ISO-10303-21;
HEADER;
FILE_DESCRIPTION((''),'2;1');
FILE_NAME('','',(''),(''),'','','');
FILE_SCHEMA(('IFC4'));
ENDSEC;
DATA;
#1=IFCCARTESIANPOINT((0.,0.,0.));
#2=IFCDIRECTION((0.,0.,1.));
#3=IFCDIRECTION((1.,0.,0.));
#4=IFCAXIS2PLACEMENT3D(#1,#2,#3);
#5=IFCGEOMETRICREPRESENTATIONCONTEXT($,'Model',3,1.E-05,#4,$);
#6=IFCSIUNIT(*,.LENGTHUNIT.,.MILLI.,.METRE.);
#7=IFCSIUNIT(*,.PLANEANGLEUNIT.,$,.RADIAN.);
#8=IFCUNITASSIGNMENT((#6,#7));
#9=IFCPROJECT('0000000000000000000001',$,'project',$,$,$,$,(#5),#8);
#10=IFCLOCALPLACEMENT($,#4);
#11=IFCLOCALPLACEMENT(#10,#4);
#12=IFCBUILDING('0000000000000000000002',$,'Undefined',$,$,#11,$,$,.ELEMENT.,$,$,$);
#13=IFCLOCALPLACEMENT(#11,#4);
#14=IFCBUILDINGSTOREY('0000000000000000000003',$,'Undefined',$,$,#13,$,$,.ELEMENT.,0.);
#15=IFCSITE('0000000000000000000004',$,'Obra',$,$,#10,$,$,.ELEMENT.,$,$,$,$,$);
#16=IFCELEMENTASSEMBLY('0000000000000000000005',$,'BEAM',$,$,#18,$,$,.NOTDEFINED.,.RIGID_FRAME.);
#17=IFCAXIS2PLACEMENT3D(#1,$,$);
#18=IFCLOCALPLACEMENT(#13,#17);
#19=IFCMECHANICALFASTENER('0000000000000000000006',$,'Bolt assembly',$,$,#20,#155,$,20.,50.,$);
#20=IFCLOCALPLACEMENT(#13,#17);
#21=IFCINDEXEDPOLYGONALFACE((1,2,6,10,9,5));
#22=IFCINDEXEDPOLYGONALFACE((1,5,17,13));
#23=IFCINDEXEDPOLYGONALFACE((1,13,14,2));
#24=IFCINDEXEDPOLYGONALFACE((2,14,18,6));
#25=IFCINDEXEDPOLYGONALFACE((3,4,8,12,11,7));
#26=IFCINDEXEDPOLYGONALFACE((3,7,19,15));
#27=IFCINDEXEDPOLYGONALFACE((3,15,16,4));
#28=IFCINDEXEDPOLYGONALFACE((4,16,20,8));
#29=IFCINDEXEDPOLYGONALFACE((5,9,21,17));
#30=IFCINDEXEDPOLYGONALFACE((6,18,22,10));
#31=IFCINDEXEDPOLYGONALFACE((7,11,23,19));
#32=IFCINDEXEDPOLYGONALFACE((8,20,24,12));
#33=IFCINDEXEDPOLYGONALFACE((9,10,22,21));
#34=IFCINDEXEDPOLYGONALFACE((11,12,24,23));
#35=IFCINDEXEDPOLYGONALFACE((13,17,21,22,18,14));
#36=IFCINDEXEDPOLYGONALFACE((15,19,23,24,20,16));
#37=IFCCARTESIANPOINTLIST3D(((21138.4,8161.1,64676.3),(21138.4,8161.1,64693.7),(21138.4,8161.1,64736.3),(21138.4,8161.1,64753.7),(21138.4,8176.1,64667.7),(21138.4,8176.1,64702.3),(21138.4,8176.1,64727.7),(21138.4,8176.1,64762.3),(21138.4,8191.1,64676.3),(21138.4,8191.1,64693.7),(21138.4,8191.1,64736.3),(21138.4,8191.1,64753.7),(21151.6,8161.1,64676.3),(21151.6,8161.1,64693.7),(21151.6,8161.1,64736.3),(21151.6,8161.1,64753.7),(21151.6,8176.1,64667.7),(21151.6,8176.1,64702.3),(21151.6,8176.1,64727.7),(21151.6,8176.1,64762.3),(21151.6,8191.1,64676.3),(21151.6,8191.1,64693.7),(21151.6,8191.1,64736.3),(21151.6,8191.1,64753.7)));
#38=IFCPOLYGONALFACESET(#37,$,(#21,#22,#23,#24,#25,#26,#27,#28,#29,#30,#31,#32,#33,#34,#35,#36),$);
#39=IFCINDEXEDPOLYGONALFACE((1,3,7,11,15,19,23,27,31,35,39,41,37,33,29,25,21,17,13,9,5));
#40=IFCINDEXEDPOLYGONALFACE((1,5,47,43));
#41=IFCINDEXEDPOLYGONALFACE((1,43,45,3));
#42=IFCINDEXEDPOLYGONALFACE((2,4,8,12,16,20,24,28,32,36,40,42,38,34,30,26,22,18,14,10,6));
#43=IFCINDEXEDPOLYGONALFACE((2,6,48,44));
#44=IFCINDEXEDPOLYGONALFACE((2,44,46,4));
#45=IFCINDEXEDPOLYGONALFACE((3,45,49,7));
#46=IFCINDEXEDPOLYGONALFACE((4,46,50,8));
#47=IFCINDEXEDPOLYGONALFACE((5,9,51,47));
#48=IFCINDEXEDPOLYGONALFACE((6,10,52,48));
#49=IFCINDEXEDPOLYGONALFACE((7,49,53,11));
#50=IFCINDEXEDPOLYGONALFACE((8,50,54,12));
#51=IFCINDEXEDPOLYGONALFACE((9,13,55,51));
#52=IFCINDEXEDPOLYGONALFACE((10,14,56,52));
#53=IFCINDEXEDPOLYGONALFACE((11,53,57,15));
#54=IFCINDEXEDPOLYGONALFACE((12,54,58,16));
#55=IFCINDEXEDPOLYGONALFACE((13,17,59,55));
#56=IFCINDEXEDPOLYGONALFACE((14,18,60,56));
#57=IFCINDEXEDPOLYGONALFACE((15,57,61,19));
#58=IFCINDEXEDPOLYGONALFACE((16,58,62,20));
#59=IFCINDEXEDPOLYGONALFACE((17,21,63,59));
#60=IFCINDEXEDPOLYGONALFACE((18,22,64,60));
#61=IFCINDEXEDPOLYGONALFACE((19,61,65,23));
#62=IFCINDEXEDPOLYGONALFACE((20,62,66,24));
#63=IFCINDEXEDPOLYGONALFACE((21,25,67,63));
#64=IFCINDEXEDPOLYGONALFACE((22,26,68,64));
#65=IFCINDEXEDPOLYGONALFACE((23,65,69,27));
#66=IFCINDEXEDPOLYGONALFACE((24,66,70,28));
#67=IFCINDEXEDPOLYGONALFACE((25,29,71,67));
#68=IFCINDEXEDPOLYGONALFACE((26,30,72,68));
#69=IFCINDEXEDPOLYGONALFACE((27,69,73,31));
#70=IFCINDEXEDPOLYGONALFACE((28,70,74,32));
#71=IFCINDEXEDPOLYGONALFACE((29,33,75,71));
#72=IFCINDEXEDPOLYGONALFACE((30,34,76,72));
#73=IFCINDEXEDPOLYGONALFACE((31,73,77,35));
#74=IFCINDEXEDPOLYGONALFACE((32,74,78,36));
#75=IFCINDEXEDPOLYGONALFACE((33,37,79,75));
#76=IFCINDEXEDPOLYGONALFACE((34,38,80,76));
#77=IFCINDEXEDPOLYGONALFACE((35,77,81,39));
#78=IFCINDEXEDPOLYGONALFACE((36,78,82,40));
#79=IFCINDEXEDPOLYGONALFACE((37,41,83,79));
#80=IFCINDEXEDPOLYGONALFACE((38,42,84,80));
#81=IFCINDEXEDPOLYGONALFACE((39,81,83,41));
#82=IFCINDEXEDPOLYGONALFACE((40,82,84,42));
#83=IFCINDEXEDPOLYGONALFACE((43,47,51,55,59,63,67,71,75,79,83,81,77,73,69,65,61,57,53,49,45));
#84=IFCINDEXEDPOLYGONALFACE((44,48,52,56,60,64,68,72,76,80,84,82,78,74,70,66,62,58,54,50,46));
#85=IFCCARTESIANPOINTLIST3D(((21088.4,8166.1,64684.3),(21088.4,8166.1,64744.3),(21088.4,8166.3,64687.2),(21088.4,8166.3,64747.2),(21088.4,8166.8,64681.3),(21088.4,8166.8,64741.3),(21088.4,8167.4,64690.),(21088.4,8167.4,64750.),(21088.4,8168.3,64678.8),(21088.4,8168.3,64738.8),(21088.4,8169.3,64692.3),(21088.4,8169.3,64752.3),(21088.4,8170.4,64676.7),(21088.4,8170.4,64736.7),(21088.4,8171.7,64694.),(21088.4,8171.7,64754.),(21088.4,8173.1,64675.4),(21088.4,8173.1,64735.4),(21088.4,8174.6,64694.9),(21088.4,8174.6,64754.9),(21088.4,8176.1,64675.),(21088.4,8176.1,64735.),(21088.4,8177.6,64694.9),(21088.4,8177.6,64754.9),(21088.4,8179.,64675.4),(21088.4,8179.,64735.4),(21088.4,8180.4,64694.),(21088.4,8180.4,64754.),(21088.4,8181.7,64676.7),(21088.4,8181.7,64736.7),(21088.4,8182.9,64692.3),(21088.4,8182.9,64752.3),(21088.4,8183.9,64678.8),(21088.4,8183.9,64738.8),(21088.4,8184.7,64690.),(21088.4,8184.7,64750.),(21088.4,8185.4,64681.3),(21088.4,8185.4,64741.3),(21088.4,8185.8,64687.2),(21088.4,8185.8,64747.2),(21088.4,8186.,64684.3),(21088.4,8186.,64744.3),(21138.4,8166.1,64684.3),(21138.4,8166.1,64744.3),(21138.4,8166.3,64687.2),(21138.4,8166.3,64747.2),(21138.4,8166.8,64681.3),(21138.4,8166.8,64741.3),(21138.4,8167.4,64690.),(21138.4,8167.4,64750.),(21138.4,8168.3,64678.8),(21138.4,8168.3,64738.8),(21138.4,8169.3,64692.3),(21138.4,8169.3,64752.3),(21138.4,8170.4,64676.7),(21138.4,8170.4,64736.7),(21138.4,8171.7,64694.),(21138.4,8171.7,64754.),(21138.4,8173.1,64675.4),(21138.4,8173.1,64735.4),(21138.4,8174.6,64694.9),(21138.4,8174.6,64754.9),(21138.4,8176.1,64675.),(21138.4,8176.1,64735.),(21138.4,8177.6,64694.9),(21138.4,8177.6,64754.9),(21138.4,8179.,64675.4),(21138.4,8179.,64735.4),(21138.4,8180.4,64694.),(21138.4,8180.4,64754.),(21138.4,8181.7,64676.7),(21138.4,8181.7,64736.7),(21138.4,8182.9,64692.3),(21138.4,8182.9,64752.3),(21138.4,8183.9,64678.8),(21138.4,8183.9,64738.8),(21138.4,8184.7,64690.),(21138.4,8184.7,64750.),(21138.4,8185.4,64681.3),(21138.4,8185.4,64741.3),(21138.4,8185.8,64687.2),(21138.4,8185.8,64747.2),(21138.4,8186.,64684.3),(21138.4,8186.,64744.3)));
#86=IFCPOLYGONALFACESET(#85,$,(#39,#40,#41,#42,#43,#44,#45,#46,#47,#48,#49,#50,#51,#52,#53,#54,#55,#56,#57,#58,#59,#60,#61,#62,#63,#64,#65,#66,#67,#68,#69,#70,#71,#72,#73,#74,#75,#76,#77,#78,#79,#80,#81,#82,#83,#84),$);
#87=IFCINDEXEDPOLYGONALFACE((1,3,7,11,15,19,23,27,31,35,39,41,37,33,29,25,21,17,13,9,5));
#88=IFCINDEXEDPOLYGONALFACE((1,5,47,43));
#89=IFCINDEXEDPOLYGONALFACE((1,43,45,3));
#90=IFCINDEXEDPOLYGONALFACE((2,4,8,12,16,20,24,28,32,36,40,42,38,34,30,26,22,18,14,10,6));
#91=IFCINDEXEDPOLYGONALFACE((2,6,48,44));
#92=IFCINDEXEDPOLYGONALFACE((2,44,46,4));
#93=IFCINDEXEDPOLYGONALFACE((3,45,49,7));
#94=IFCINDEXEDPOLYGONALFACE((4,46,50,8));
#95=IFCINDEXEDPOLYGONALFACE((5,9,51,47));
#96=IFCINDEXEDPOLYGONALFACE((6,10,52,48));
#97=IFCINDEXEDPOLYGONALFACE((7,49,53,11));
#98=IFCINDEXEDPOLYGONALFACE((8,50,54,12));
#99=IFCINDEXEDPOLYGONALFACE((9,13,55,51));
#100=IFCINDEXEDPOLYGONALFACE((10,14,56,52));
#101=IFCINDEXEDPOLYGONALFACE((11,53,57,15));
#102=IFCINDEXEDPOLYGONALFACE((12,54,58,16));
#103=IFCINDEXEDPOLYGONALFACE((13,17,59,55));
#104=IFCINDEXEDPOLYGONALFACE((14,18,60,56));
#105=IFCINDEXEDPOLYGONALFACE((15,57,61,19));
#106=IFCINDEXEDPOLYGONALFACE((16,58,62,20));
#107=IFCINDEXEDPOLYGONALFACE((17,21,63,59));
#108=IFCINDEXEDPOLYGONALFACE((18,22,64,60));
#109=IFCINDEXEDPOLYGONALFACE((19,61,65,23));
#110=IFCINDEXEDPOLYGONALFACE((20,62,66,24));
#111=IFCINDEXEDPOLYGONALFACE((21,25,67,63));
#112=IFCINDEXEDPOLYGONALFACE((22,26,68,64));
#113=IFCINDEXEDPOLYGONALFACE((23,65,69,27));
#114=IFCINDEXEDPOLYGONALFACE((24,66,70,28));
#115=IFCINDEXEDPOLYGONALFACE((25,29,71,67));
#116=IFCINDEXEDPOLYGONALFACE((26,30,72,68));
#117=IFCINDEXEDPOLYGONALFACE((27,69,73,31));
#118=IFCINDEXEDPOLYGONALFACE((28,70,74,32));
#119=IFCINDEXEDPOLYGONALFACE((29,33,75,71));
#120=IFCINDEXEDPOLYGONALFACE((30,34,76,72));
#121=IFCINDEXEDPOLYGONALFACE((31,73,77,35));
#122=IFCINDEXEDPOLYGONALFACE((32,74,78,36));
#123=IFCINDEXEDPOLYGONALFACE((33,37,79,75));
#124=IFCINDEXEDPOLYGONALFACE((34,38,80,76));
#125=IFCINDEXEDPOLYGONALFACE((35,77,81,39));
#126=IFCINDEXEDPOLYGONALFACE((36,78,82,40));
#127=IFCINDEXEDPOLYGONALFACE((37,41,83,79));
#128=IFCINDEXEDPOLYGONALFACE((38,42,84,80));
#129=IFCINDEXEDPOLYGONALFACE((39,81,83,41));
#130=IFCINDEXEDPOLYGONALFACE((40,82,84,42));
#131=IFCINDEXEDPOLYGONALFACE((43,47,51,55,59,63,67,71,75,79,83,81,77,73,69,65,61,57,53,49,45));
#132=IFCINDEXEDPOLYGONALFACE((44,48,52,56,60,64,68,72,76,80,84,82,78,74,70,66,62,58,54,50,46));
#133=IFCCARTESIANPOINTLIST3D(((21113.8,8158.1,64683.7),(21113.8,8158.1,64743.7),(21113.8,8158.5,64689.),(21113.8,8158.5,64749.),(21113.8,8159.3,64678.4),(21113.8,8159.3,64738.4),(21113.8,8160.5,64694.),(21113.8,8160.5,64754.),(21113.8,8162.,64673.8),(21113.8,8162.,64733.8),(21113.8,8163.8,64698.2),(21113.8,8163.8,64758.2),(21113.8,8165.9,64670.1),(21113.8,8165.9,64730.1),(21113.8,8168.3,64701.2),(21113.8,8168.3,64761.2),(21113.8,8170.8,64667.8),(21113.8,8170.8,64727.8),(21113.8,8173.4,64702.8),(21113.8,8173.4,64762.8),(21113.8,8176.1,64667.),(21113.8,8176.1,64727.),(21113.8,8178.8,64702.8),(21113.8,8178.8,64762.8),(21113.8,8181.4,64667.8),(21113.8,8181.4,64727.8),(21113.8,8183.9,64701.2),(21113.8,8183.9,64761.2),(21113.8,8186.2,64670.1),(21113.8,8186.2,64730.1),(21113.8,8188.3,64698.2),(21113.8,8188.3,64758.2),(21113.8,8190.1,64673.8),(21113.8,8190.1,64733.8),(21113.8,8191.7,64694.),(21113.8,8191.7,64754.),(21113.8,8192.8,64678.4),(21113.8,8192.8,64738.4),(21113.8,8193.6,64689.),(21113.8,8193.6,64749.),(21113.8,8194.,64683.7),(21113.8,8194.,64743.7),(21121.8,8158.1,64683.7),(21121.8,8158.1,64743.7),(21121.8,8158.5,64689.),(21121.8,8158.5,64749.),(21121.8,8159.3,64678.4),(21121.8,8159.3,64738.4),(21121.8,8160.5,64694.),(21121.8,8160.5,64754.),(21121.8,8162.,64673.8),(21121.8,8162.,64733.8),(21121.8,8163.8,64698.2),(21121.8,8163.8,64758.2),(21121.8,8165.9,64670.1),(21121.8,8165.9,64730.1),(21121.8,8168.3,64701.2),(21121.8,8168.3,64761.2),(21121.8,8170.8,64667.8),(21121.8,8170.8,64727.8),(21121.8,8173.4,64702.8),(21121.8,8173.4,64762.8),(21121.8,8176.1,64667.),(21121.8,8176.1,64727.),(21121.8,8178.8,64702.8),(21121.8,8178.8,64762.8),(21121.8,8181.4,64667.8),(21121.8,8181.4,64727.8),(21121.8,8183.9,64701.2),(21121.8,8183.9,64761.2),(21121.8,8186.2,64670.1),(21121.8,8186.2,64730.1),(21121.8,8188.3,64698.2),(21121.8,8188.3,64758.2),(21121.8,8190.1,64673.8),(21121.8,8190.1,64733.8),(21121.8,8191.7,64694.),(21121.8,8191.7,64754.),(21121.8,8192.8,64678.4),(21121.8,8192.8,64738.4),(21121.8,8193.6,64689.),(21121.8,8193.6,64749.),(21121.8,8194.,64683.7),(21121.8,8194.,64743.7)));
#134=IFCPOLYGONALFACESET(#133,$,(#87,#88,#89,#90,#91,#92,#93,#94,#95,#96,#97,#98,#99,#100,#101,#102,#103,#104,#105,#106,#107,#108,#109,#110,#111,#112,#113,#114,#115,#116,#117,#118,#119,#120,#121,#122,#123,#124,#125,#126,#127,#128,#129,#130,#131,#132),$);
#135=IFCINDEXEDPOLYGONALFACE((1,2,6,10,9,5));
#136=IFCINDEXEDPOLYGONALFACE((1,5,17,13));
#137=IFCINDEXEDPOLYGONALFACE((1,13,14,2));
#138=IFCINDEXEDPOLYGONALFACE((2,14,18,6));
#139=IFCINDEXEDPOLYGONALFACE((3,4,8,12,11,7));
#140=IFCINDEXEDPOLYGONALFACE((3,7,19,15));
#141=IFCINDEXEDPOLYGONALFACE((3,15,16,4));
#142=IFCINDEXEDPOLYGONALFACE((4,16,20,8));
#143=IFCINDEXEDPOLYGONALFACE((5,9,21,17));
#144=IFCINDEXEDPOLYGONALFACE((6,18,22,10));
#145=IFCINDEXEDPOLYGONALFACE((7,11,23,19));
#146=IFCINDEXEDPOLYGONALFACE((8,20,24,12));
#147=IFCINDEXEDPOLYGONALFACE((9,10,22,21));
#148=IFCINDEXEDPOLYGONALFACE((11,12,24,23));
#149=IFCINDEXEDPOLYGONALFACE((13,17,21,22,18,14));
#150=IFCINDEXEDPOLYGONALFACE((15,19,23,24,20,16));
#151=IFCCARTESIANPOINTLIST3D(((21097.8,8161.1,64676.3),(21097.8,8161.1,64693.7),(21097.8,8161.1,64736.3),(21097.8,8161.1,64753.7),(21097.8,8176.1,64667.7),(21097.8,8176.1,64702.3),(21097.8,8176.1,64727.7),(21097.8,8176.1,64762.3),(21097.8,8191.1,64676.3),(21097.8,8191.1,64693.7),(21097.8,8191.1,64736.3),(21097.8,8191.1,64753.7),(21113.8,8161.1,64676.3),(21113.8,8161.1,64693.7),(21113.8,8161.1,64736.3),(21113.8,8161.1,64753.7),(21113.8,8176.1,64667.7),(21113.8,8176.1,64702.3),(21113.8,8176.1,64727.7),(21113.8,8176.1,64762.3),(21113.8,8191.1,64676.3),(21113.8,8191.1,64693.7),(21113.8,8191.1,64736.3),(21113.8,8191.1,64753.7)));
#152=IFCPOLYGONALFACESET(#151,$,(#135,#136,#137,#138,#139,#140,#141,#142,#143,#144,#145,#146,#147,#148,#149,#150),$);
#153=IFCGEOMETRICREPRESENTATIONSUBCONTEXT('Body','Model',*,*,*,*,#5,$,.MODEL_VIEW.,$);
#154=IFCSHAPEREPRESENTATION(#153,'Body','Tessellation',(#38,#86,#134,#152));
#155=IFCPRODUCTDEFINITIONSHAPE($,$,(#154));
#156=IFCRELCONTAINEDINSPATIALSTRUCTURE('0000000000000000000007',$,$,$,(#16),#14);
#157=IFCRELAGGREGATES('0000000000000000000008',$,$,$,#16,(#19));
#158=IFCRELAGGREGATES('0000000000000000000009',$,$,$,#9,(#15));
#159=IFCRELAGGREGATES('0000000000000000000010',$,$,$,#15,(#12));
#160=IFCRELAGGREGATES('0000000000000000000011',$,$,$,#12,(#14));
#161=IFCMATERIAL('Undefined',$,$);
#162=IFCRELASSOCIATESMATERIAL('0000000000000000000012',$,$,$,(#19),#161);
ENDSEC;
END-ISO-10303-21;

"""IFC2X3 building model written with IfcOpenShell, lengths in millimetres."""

from ifc_helpers import new_model, si_unit, frame, origin_with_axes, origin_2d_with_axis, place, context, subcontext, project, spatial, polyline, circle, outline, extrude, source, transform, mapped, material, element, aggregate, save


model = new_model("IFC2X3")

# Units and contexts
model_context = context("Model", 3, precision=1e-05, world=origin_with_axes())
body_context = subcontext(model_context, "Body", "Model", "MODEL_VIEW")
ifc_project = project(units=[si_unit("LENGTHUNIT", "METRE", prefix="MILLI"), si_unit("PLANEANGLEUNIT", "RADIAN")], contexts=[model_context])

# Site, building, storey
site_placement = place(None, origin_with_axes())
site = spatial("IfcSite", under=ifc_project, at=site_placement, Name="Obra", CompositionType="ELEMENT")
building_placement = place(site_placement, origin_with_axes())
building = spatial("IfcBuilding", under=site, at=building_placement, Name="Undefined", CompositionType="ELEMENT")
storey_placement = place(building_placement, origin_with_axes())
storey = spatial("IfcBuildingStorey", under=building, at=storey_placement, Name="Undefined", CompositionType="ELEMENT", Elevation=0.0)

# Shared definitions
ifc_material = material(Name="Undefined")
shared_shape_1 = source(origin_with_axes(), body_context, "Body", "SweptSolid", [
    extrude(outline(polyline([(17.3, 0.0), (8.7, 15.0), (-8.7, 15.0), (-17.3, 0.0), (-8.7, -15.0), (8.7, -15.0), (17.3, 0.0)])), frame((0.0, -26.5, 0.0), z_axis=(0.0, 1.0, 0.0), x_axis=(1.0, 0.0, 0.0)), (0.0, 0.0, 1.0), 13.2),
    extrude(circle(Radius=10.0, at=origin_2d_with_axis()), frame((0.0, -13.3, 0.0), z_axis=(0.0, 1.0, 0.0), x_axis=(1.0, 0.0, 0.0)), (0.0, 0.0, 1.0), 50.0),
    extrude(circle(Radius=18.0, at=origin_2d_with_axis()), frame((0.0, 3.3, 0.0), z_axis=(0.0, 1.0, 0.0), x_axis=(1.0, 0.0, 0.0)), (0.0, 0.0, 1.0), 8.0),
    extrude(outline(polyline([(17.3, 0.0), (8.7, 15.0), (-8.7, 15.0), (-17.3, 0.0), (-8.7, -15.0), (8.7, -15.0), (17.3, 0.0)])), frame((0.0, 11.3, 0.0), z_axis=(0.0, 1.0, 0.0), x_axis=(1.0, 0.0, 0.0)), (0.0, 0.0, 1.0), 16.0),
])

# Element assembly
assembly_1_placement = place(storey_placement, origin_with_axes())
assembly_1 = element("IfcElementAssembly", 1, at=assembly_1_placement, inside=storey, Name="BEAM", AssemblyPlace="NOTDEFINED", PredefinedType="RIGID_FRAME")

# Mechanical fastener
mechanical_fastener_1_placement = place(assembly_1_placement, frame((21125.1, 8136.1, 64850.0), z_axis=(0.0, 1.0, 0.0), x_axis=(0.0, 0.0, -1.0)))
mechanical_fastener_1 = element("IfcMechanicalFastener", 2, at=mechanical_fastener_1_placement, material=ifc_material, Name="Bolt assembly", NominalDiameter=20.0, NominalLength=50.0, context=body_context, shape_type="MappedRepresentation", body=[
    mapped(shared_shape_1, transform((105.0, 0.0, 40.0))),
    mapped(shared_shape_1, transform((165.0, 0.0, 40.0))),
])
aggregate(assembly_1, [mechanical_fastener_1])

save(model, "model.ifc")
